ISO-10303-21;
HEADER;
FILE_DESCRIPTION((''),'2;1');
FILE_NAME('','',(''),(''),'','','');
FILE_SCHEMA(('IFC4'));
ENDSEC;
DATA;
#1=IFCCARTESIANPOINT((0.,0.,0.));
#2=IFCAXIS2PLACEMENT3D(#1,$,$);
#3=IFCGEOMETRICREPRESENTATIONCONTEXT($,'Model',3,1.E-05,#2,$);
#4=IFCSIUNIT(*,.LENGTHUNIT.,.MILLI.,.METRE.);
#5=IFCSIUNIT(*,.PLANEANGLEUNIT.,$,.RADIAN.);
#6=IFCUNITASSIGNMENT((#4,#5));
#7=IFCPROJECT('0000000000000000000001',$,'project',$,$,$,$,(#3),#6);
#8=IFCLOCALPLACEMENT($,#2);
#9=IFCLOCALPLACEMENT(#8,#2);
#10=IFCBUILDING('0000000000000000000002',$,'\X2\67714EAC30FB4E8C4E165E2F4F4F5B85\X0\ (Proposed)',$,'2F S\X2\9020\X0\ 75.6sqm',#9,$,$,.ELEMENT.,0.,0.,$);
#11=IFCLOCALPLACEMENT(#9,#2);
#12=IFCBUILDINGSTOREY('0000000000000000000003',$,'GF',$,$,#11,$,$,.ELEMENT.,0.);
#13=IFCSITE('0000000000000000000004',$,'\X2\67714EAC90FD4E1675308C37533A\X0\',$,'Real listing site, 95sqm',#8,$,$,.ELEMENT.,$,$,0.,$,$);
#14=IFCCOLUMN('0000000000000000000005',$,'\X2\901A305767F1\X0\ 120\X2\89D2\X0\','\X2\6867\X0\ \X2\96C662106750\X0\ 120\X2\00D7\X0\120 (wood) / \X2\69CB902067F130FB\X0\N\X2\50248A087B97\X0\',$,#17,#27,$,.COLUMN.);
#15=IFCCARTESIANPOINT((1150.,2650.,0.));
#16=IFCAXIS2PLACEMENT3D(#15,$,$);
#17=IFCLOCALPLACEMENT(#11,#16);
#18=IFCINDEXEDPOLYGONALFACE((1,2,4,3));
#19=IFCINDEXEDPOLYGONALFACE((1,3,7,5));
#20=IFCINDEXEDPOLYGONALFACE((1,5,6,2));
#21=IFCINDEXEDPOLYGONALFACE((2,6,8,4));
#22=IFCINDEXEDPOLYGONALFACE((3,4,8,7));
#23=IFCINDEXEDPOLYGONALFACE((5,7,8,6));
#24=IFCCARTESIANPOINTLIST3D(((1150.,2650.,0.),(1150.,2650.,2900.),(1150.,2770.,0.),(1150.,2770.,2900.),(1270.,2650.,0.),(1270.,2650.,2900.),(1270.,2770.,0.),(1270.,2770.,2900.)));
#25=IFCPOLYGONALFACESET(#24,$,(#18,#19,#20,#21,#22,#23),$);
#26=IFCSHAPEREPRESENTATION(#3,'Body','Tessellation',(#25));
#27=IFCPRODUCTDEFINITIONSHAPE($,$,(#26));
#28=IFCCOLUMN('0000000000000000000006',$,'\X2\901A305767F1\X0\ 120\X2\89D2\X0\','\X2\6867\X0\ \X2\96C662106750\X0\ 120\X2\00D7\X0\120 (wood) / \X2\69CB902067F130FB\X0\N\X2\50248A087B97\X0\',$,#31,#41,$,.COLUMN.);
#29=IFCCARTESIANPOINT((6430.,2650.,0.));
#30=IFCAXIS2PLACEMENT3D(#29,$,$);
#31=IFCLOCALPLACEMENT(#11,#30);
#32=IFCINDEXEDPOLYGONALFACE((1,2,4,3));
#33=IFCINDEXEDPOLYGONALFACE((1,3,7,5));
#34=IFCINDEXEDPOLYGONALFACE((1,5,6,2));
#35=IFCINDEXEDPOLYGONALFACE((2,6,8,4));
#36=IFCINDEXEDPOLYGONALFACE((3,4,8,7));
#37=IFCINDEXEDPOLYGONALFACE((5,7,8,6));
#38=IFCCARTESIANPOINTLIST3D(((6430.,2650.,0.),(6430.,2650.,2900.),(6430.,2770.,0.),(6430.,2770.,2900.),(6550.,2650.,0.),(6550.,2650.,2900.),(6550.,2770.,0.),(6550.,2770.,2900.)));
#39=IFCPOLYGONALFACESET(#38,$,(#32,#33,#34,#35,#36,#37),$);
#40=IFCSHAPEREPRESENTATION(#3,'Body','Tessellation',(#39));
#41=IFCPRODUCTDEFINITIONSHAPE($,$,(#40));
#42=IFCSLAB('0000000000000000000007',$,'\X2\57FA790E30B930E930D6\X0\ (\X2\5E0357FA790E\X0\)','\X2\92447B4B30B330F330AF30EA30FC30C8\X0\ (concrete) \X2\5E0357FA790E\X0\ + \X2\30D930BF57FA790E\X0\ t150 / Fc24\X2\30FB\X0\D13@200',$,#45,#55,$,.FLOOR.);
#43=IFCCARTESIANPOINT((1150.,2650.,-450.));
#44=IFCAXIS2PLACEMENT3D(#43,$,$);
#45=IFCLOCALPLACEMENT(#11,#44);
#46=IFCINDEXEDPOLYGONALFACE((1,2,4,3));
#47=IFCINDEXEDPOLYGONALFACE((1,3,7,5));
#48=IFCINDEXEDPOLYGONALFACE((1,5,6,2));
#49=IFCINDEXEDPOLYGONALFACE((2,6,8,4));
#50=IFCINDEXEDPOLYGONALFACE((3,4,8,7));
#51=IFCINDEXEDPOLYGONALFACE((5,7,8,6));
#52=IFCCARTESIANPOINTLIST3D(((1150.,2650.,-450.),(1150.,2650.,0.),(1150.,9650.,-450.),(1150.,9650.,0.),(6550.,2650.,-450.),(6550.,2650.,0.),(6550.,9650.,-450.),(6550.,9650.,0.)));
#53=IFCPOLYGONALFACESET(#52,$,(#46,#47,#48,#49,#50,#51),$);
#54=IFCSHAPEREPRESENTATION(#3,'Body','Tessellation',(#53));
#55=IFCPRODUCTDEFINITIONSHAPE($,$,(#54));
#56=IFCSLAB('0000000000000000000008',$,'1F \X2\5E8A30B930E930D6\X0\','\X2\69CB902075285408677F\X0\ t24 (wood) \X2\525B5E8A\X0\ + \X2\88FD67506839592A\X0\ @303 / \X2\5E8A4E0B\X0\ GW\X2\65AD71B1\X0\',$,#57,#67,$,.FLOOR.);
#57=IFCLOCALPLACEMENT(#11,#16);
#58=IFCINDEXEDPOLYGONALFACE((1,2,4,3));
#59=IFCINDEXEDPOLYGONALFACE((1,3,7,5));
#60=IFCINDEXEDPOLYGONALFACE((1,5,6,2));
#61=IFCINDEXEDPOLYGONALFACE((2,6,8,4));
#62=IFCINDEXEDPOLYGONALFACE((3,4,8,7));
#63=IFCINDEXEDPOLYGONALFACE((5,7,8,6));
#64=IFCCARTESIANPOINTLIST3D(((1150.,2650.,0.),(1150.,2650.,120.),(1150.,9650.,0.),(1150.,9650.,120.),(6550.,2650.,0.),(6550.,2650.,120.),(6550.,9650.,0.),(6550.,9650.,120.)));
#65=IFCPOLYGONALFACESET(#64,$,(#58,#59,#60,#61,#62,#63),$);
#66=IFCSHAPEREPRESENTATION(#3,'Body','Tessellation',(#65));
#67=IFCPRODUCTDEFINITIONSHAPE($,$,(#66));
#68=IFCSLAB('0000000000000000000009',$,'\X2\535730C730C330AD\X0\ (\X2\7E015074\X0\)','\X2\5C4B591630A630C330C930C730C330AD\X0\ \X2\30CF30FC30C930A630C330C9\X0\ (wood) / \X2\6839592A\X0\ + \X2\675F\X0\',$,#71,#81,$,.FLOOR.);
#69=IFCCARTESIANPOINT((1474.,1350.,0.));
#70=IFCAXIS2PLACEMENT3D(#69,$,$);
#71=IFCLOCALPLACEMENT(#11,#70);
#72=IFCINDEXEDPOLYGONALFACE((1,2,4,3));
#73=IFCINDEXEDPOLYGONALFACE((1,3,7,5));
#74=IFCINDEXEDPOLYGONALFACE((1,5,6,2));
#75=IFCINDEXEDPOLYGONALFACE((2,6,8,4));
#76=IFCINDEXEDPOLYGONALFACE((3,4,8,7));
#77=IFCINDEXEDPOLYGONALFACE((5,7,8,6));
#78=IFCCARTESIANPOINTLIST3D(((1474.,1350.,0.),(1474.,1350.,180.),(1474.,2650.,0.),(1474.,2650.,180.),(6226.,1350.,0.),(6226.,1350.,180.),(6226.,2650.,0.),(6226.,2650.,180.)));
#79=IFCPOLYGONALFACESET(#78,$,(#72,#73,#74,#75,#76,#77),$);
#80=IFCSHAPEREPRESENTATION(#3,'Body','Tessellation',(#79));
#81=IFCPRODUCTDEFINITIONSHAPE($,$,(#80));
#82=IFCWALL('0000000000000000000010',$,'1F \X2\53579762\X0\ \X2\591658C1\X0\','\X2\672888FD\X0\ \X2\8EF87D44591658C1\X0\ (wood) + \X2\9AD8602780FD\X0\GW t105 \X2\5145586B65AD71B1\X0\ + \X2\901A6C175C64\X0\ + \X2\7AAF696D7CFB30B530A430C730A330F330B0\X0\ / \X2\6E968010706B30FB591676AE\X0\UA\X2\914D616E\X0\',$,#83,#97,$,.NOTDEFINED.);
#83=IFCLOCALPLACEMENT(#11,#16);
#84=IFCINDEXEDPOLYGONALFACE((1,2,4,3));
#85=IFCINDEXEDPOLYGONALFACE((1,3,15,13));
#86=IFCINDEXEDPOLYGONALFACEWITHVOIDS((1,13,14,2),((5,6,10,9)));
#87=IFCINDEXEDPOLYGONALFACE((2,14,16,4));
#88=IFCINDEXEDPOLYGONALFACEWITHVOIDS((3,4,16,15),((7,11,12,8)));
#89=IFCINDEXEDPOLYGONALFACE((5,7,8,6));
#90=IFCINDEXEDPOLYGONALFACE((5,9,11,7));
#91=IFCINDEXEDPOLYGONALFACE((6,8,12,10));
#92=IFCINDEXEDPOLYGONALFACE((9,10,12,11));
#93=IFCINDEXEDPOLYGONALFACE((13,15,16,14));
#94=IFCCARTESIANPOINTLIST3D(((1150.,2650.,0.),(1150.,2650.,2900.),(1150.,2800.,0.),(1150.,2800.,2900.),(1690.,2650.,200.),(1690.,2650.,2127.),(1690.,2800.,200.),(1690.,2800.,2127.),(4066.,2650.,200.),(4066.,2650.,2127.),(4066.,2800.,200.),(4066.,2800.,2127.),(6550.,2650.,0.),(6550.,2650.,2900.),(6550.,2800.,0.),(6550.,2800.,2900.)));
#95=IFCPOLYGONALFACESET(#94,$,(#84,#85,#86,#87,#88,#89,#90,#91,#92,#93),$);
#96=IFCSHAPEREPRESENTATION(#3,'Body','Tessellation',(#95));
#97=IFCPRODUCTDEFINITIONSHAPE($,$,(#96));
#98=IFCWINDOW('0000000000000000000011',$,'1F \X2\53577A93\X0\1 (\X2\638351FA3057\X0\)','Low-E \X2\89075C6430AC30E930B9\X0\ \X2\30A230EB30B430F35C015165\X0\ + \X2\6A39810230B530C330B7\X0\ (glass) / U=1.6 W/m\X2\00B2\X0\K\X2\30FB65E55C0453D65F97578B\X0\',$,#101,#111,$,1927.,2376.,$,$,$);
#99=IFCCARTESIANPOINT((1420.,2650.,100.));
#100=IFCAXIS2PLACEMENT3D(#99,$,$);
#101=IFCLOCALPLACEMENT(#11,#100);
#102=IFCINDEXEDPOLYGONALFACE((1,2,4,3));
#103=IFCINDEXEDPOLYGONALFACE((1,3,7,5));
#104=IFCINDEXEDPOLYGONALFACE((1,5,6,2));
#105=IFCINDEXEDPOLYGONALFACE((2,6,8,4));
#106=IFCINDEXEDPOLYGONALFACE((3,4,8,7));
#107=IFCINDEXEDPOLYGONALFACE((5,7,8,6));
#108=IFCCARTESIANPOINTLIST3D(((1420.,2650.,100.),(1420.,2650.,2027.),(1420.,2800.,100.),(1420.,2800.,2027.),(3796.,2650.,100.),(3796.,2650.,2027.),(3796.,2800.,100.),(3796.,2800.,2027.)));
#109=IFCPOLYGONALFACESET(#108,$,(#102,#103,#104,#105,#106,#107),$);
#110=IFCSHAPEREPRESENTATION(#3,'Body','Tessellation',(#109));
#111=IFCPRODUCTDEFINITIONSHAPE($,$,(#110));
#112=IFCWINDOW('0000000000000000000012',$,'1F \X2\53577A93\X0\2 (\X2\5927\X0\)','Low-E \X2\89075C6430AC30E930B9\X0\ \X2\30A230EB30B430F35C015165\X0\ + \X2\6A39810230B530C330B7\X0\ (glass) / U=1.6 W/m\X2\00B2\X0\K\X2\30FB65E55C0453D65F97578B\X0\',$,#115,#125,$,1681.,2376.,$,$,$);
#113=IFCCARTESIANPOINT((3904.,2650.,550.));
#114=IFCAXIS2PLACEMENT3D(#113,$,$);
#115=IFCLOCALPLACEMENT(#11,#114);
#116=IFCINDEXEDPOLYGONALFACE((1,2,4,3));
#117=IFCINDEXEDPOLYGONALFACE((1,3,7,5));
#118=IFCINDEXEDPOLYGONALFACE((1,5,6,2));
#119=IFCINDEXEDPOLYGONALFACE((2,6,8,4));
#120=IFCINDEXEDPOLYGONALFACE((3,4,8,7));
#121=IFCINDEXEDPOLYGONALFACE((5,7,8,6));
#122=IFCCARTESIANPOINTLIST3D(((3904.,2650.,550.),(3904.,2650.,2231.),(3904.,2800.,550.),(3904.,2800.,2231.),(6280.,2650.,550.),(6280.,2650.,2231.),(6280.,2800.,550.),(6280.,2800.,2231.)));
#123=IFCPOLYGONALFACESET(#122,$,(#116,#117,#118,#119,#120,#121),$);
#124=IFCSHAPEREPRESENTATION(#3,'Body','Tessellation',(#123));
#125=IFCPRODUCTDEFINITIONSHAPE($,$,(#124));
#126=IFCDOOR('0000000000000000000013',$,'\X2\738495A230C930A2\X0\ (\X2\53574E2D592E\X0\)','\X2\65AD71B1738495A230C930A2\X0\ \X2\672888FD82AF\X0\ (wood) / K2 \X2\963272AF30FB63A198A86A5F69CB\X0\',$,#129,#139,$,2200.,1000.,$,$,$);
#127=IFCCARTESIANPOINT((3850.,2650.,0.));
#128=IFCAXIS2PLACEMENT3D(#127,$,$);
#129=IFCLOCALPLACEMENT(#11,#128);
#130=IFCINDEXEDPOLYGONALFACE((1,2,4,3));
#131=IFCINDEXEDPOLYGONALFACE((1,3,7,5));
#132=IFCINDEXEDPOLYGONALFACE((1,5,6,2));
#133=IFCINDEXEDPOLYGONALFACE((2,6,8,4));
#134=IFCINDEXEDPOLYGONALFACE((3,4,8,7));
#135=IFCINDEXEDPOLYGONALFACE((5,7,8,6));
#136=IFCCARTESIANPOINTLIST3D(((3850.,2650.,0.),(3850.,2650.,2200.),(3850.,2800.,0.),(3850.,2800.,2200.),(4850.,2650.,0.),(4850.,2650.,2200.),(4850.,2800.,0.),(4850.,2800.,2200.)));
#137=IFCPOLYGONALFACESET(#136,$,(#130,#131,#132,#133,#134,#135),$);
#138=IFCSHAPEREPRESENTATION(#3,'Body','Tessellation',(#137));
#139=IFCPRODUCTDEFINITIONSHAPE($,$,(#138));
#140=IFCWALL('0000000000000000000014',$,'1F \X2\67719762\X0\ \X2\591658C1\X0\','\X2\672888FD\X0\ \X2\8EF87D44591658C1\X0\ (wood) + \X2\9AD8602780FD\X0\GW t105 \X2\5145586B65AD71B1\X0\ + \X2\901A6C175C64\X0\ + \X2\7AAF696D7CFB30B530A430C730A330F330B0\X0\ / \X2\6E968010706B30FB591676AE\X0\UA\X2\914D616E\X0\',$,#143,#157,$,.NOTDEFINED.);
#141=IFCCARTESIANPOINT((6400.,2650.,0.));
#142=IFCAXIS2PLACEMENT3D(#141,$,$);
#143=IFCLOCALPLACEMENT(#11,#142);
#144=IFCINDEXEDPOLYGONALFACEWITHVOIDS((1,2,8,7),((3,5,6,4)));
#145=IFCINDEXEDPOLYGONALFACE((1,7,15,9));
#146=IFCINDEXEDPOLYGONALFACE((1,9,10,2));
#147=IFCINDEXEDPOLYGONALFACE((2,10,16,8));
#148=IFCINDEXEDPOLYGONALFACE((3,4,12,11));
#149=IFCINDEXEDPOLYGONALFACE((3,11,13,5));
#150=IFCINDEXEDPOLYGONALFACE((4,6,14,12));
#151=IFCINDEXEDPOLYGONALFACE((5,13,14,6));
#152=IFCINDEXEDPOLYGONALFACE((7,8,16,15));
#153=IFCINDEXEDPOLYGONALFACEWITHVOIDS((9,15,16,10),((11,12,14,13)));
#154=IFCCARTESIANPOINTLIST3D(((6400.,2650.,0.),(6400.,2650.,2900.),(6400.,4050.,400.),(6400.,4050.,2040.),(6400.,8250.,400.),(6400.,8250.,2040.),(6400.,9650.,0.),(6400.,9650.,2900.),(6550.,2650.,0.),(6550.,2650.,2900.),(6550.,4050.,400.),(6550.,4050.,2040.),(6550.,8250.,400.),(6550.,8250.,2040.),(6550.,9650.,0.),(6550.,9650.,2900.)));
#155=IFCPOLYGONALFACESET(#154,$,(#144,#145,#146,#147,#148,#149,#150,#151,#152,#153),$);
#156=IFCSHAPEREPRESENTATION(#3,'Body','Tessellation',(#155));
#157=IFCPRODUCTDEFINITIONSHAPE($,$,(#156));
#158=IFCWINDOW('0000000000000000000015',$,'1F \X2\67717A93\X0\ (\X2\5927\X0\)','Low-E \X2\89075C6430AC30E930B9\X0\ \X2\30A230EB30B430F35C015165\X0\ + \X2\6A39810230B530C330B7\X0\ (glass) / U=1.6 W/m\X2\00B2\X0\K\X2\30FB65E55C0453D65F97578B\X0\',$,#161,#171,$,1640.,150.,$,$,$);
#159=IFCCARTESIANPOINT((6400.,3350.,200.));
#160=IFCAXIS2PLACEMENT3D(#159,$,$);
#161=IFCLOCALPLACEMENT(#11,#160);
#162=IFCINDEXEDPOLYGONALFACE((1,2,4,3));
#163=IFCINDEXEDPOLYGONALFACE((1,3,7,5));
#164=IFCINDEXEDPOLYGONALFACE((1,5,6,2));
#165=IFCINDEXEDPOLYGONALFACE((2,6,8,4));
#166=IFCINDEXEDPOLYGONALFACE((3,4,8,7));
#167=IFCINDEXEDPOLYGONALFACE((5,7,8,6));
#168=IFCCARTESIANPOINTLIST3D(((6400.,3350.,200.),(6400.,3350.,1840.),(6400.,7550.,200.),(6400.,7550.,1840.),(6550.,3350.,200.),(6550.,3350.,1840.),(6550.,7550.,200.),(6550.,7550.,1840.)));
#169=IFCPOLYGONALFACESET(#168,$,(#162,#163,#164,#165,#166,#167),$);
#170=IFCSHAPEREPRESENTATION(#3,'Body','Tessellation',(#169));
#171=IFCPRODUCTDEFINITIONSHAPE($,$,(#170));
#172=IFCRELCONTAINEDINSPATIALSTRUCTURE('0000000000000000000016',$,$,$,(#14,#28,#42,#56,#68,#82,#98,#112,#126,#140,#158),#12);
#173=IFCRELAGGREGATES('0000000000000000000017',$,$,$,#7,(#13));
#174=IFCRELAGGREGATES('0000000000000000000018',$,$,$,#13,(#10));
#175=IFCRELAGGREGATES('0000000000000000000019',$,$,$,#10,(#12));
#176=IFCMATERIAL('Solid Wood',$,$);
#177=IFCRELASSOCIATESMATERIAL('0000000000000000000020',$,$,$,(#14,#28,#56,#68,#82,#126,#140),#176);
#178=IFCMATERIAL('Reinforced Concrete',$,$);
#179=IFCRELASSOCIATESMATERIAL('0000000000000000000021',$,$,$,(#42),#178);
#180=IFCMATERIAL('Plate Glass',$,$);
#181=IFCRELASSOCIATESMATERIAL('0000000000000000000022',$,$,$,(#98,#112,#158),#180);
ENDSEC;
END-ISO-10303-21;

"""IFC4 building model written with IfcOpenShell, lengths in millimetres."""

from ifc_helpers import new_model, si_unit, frame, frame_2d, origin, place, context, project, spatial, rectangle, extrude, material, element, fill, save


model = new_model("IFC4")

# Units and contexts
model_context = context("Model", 3, precision=1e-05, world=origin())
ifc_project = project(units=[si_unit("LENGTHUNIT", "METRE", prefix="MILLI"), si_unit("PLANEANGLEUNIT", "RADIAN")], contexts=[model_context])

# Site, building, storey
site_placement = place(None, origin())
site = spatial("IfcSite", under=ifc_project, at=site_placement, Name="東京都世田谷区", ObjectType="Real listing site, 95sqm", CompositionType="ELEMENT", RefElevation=0.0)
building_placement = place(site_placement, origin())
building = spatial("IfcBuilding", under=site, at=building_placement, Name="東京・二世帯住宅 (Proposed)", ObjectType="2F S造 75.6sqm", CompositionType="ELEMENT", ElevationOfRefHeight=0.0, ElevationOfTerrain=0.0)
storey_placement = place(building_placement, origin())
storey = spatial("IfcBuildingStorey", under=building, at=storey_placement, Name="GF", CompositionType="ELEMENT", Elevation=0.0)

# Columns
ifc_material_1 = material(Name="Solid Wood")
column_1_placement = place(storey_placement, frame((1150.0, 2650.0, 0.0)))
element("IfcColumn", 1, at=column_1_placement, inside=storey, material=ifc_material_1, Name="通し柱 120角", Description="桧 集成材 120×120 (wood) / 構造柱・N値計算", PredefinedType="COLUMN", context=model_context, shape_type="SweptSolid", body=[
    extrude(rectangle(XDim=120.0, YDim=120.0, at=frame_2d((60.0, 60.0))), frame((1150.0, 2650.0, 0.0)), (0.0, 0.0, 1.0), 2900.0),
])
column_2_placement = place(storey_placement, frame((6430.0, 2650.0, 0.0)))
element("IfcColumn", 2, at=column_2_placement, inside=storey, material=ifc_material_1, Name="通し柱 120角", Description="桧 集成材 120×120 (wood) / 構造柱・N値計算", PredefinedType="COLUMN", context=model_context, shape_type="SweptSolid", body=[
    extrude(rectangle(XDim=120.0, YDim=120.0, at=frame_2d((60.0, 60.0))), frame((6430.0, 2650.0, 0.0)), (0.0, 0.0, 1.0), 2900.0),
])

# Slabs
ifc_material_2 = material(Name="Reinforced Concrete")
slab_1_placement = place(storey_placement, frame((1150.0, 2650.0, -450.0)))
element("IfcSlab", 3, at=slab_1_placement, inside=storey, material=ifc_material_2, Name="基礎スラブ (布基礎)", Description="鉄筋コンクリート (concrete) 布基礎 + ベタ基礎 t150 / Fc24・D13@200", PredefinedType="FLOOR", context=model_context, shape_type="SweptSolid", body=[
    extrude(rectangle(XDim=5400.0, YDim=7000.0, at=frame_2d((2700.0, 3500.0))), frame((1150.0, 2650.0, -450.0)), (0.0, 0.0, 1.0), 450.0),
])
slab_2_placement = place(storey_placement, frame((1150.0, 2650.0, 0.0)))
element("IfcSlab", 4, at=slab_2_placement, inside=storey, material=ifc_material_1, Name="1F 床スラブ", Description="構造用合板 t24 (wood) 剛床 + 製材根太 @303 / 床下 GW断熱", PredefinedType="FLOOR", context=model_context, shape_type="SweptSolid", body=[
    extrude(rectangle(XDim=5400.0, YDim=7000.0, at=frame_2d((2700.0, 3500.0))), frame((1150.0, 2650.0, 0.0)), (0.0, 0.0, 1.0), 120.0),
])
slab_3_placement = place(storey_placement, frame((1474.0, 1350.0, 0.0)))
element("IfcSlab", 5, at=slab_3_placement, inside=storey, material=ifc_material_1, Name="南デッキ (縁側)", Description="屋外ウッドデッキ ハードウッド (wood) / 根太 + 束", PredefinedType="FLOOR", context=model_context, shape_type="SweptSolid", body=[
    extrude(rectangle(XDim=4752.0, YDim=1300.0, at=frame_2d((2376.0, 650.0))), frame((1474.0, 1350.0, 0.0)), (0.0, 0.0, 1.0), 180.0),
])

# Wall, openings, windows, door
wall_1_placement = place(storey_placement, frame((1150.0, 2650.0, 0.0)))
wall_1 = element("IfcWall", 6, at=wall_1_placement, inside=storey, material=ifc_material_1, Name="1F 南面 外壁", Description="木製 軸組外壁 (wood) + 高性能GW t105 充填断熱 + 通気層 + 窯業系サイディング / 準耐火・外皮UA配慮", PredefinedType="NOTDEFINED", context=model_context, shape_type="SweptSolid", body=[
    extrude(rectangle(XDim=5400.0, YDim=150.0, at=frame_2d((2700.0, 75.0))), frame((1150.0, 2650.0, 0.0)), (0.0, 0.0, 1.0), 2900.0),
])
opening_1_placement = place(storey_placement, frame((1420.0, 2650.0, 100.0)))
opening_1 = element("IfcOpeningElement", 7, at=opening_1_placement, cuts=wall_1, PredefinedType="NOTDEFINED", context=model_context, shape_type="SweptSolid", body=[
    extrude(rectangle(XDim=2376.0, YDim=150.0, at=frame_2d((1188.0, 75.0))), frame((1420.0, 2650.0, 100.0)), (0.0, 0.0, 1.0), 1927.0),
])
opening_2_placement = place(storey_placement, frame((3904.0, 2650.0, 550.0)))
opening_2 = element("IfcOpeningElement", 8, at=opening_2_placement, cuts=wall_1, PredefinedType="NOTDEFINED", context=model_context, shape_type="SweptSolid", body=[
    extrude(rectangle(XDim=2376.0, YDim=150.0, at=frame_2d((1188.0, 75.0))), frame((3904.0, 2650.0, 550.0)), (0.0, 0.0, 1.0), 1681.0),
])
opening_3_placement = place(storey_placement, frame((3850.0, 2650.0, 0.0)))
opening_3 = element("IfcOpeningElement", 9, at=opening_3_placement, cuts=wall_1, PredefinedType="NOTDEFINED", context=model_context, shape_type="SweptSolid", body=[
    extrude(rectangle(XDim=1000.0, YDim=150.0, at=frame_2d((500.0, 75.0))), frame((3850.0, 2650.0, 0.0)), (0.0, 0.0, 1.0), 2200.0),
])
ifc_material_3 = material(Name="Plate Glass")
window_1_placement = place(storey_placement, frame((1420.0, 2650.0, 100.0)))
window_1 = element("IfcWindow", 10, at=window_1_placement, inside=storey, material=ifc_material_3, Name="1F 南窓1 (掃出し)", Description="Low-E 複層ガラス アルゴン封入 + 樹脂サッシ (glass) / U=1.6 W/m²K・日射取得型", OverallHeight=1927.0, OverallWidth=2376.0, context=model_context, shape_type="SweptSolid", body=[
    extrude(rectangle(XDim=2376.0, YDim=150.0, at=frame_2d((1188.0, 75.0))), frame((1420.0, 2650.0, 100.0)), (0.0, 0.0, 1.0), 1927.0),
])
fill(opening_1, window_1)
window_2_placement = place(storey_placement, frame((3904.0, 2650.0, 550.0)))
window_2 = element("IfcWindow", 11, at=window_2_placement, inside=storey, material=ifc_material_3, Name="1F 南窓2 (大)", Description="Low-E 複層ガラス アルゴン封入 + 樹脂サッシ (glass) / U=1.6 W/m²K・日射取得型", OverallHeight=1681.0, OverallWidth=2376.0, context=model_context, shape_type="SweptSolid", body=[
    extrude(rectangle(XDim=2376.0, YDim=150.0, at=frame_2d((1188.0, 75.0))), frame((3904.0, 2650.0, 550.0)), (0.0, 0.0, 1.0), 1681.0),
])
fill(opening_2, window_2)
door_placement = place(storey_placement, frame((3850.0, 2650.0, 0.0)))
door = element("IfcDoor", 12, at=door_placement, inside=storey, material=ifc_material_1, Name="玄関ドア (南中央)", Description="断熱玄関ドア 木製芯 (wood) / K2 防犯・採風機構", OverallHeight=2200.0, OverallWidth=1000.0, context=model_context, shape_type="SweptSolid", body=[
    extrude(rectangle(XDim=1000.0, YDim=150.0, at=frame_2d((500.0, 75.0))), frame((3850.0, 2650.0, 0.0)), (0.0, 0.0, 1.0), 2200.0),
])
fill(opening_3, door)

# Wall, opening, window
wall_2_placement = place(storey_placement, frame((6400.0, 2650.0, 0.0)))
wall_2 = element("IfcWall", 13, at=wall_2_placement, inside=storey, material=ifc_material_1, Name="1F 東面 外壁", Description="木製 軸組外壁 (wood) + 高性能GW t105 充填断熱 + 通気層 + 窯業系サイディング / 準耐火・外皮UA配慮", PredefinedType="NOTDEFINED", context=model_context, shape_type="SweptSolid", body=[
    extrude(rectangle(XDim=150.0, YDim=7000.0, at=frame_2d((75.0, 3500.0))), frame((6400.0, 2650.0, 0.0)), (0.0, 0.0, 1.0), 2900.0),
])
opening_4_placement = place(storey_placement, frame((6400.0, 3350.0, 200.0)))
opening_4 = element("IfcOpeningElement", 14, at=opening_4_placement, cuts=wall_2, PredefinedType="NOTDEFINED", context=model_context, shape_type="SweptSolid", body=[
    extrude(rectangle(XDim=150.0, YDim=4200.0, at=frame_2d((75.0, 2100.0))), frame((6400.0, 3350.0, 200.0)), (0.0, 0.0, 1.0), 1640.0),
])
window_3_placement = place(storey_placement, frame((6400.0, 3350.0, 200.0)))
window_3 = element("IfcWindow", 15, at=window_3_placement, inside=storey, material=ifc_material_3, Name="1F 東窓 (大)", Description="Low-E 複層ガラス アルゴン封入 + 樹脂サッシ (glass) / U=1.6 W/m²K・日射取得型", OverallHeight=1640.0, OverallWidth=150.0, context=model_context, shape_type="SweptSolid", body=[
    extrude(rectangle(XDim=150.0, YDim=4200.0, at=frame_2d((75.0, 2100.0))), frame((6400.0, 3350.0, 200.0)), (0.0, 0.0, 1.0), 1640.0),
])
fill(opening_4, window_3)

save(model, "model.ifc")
